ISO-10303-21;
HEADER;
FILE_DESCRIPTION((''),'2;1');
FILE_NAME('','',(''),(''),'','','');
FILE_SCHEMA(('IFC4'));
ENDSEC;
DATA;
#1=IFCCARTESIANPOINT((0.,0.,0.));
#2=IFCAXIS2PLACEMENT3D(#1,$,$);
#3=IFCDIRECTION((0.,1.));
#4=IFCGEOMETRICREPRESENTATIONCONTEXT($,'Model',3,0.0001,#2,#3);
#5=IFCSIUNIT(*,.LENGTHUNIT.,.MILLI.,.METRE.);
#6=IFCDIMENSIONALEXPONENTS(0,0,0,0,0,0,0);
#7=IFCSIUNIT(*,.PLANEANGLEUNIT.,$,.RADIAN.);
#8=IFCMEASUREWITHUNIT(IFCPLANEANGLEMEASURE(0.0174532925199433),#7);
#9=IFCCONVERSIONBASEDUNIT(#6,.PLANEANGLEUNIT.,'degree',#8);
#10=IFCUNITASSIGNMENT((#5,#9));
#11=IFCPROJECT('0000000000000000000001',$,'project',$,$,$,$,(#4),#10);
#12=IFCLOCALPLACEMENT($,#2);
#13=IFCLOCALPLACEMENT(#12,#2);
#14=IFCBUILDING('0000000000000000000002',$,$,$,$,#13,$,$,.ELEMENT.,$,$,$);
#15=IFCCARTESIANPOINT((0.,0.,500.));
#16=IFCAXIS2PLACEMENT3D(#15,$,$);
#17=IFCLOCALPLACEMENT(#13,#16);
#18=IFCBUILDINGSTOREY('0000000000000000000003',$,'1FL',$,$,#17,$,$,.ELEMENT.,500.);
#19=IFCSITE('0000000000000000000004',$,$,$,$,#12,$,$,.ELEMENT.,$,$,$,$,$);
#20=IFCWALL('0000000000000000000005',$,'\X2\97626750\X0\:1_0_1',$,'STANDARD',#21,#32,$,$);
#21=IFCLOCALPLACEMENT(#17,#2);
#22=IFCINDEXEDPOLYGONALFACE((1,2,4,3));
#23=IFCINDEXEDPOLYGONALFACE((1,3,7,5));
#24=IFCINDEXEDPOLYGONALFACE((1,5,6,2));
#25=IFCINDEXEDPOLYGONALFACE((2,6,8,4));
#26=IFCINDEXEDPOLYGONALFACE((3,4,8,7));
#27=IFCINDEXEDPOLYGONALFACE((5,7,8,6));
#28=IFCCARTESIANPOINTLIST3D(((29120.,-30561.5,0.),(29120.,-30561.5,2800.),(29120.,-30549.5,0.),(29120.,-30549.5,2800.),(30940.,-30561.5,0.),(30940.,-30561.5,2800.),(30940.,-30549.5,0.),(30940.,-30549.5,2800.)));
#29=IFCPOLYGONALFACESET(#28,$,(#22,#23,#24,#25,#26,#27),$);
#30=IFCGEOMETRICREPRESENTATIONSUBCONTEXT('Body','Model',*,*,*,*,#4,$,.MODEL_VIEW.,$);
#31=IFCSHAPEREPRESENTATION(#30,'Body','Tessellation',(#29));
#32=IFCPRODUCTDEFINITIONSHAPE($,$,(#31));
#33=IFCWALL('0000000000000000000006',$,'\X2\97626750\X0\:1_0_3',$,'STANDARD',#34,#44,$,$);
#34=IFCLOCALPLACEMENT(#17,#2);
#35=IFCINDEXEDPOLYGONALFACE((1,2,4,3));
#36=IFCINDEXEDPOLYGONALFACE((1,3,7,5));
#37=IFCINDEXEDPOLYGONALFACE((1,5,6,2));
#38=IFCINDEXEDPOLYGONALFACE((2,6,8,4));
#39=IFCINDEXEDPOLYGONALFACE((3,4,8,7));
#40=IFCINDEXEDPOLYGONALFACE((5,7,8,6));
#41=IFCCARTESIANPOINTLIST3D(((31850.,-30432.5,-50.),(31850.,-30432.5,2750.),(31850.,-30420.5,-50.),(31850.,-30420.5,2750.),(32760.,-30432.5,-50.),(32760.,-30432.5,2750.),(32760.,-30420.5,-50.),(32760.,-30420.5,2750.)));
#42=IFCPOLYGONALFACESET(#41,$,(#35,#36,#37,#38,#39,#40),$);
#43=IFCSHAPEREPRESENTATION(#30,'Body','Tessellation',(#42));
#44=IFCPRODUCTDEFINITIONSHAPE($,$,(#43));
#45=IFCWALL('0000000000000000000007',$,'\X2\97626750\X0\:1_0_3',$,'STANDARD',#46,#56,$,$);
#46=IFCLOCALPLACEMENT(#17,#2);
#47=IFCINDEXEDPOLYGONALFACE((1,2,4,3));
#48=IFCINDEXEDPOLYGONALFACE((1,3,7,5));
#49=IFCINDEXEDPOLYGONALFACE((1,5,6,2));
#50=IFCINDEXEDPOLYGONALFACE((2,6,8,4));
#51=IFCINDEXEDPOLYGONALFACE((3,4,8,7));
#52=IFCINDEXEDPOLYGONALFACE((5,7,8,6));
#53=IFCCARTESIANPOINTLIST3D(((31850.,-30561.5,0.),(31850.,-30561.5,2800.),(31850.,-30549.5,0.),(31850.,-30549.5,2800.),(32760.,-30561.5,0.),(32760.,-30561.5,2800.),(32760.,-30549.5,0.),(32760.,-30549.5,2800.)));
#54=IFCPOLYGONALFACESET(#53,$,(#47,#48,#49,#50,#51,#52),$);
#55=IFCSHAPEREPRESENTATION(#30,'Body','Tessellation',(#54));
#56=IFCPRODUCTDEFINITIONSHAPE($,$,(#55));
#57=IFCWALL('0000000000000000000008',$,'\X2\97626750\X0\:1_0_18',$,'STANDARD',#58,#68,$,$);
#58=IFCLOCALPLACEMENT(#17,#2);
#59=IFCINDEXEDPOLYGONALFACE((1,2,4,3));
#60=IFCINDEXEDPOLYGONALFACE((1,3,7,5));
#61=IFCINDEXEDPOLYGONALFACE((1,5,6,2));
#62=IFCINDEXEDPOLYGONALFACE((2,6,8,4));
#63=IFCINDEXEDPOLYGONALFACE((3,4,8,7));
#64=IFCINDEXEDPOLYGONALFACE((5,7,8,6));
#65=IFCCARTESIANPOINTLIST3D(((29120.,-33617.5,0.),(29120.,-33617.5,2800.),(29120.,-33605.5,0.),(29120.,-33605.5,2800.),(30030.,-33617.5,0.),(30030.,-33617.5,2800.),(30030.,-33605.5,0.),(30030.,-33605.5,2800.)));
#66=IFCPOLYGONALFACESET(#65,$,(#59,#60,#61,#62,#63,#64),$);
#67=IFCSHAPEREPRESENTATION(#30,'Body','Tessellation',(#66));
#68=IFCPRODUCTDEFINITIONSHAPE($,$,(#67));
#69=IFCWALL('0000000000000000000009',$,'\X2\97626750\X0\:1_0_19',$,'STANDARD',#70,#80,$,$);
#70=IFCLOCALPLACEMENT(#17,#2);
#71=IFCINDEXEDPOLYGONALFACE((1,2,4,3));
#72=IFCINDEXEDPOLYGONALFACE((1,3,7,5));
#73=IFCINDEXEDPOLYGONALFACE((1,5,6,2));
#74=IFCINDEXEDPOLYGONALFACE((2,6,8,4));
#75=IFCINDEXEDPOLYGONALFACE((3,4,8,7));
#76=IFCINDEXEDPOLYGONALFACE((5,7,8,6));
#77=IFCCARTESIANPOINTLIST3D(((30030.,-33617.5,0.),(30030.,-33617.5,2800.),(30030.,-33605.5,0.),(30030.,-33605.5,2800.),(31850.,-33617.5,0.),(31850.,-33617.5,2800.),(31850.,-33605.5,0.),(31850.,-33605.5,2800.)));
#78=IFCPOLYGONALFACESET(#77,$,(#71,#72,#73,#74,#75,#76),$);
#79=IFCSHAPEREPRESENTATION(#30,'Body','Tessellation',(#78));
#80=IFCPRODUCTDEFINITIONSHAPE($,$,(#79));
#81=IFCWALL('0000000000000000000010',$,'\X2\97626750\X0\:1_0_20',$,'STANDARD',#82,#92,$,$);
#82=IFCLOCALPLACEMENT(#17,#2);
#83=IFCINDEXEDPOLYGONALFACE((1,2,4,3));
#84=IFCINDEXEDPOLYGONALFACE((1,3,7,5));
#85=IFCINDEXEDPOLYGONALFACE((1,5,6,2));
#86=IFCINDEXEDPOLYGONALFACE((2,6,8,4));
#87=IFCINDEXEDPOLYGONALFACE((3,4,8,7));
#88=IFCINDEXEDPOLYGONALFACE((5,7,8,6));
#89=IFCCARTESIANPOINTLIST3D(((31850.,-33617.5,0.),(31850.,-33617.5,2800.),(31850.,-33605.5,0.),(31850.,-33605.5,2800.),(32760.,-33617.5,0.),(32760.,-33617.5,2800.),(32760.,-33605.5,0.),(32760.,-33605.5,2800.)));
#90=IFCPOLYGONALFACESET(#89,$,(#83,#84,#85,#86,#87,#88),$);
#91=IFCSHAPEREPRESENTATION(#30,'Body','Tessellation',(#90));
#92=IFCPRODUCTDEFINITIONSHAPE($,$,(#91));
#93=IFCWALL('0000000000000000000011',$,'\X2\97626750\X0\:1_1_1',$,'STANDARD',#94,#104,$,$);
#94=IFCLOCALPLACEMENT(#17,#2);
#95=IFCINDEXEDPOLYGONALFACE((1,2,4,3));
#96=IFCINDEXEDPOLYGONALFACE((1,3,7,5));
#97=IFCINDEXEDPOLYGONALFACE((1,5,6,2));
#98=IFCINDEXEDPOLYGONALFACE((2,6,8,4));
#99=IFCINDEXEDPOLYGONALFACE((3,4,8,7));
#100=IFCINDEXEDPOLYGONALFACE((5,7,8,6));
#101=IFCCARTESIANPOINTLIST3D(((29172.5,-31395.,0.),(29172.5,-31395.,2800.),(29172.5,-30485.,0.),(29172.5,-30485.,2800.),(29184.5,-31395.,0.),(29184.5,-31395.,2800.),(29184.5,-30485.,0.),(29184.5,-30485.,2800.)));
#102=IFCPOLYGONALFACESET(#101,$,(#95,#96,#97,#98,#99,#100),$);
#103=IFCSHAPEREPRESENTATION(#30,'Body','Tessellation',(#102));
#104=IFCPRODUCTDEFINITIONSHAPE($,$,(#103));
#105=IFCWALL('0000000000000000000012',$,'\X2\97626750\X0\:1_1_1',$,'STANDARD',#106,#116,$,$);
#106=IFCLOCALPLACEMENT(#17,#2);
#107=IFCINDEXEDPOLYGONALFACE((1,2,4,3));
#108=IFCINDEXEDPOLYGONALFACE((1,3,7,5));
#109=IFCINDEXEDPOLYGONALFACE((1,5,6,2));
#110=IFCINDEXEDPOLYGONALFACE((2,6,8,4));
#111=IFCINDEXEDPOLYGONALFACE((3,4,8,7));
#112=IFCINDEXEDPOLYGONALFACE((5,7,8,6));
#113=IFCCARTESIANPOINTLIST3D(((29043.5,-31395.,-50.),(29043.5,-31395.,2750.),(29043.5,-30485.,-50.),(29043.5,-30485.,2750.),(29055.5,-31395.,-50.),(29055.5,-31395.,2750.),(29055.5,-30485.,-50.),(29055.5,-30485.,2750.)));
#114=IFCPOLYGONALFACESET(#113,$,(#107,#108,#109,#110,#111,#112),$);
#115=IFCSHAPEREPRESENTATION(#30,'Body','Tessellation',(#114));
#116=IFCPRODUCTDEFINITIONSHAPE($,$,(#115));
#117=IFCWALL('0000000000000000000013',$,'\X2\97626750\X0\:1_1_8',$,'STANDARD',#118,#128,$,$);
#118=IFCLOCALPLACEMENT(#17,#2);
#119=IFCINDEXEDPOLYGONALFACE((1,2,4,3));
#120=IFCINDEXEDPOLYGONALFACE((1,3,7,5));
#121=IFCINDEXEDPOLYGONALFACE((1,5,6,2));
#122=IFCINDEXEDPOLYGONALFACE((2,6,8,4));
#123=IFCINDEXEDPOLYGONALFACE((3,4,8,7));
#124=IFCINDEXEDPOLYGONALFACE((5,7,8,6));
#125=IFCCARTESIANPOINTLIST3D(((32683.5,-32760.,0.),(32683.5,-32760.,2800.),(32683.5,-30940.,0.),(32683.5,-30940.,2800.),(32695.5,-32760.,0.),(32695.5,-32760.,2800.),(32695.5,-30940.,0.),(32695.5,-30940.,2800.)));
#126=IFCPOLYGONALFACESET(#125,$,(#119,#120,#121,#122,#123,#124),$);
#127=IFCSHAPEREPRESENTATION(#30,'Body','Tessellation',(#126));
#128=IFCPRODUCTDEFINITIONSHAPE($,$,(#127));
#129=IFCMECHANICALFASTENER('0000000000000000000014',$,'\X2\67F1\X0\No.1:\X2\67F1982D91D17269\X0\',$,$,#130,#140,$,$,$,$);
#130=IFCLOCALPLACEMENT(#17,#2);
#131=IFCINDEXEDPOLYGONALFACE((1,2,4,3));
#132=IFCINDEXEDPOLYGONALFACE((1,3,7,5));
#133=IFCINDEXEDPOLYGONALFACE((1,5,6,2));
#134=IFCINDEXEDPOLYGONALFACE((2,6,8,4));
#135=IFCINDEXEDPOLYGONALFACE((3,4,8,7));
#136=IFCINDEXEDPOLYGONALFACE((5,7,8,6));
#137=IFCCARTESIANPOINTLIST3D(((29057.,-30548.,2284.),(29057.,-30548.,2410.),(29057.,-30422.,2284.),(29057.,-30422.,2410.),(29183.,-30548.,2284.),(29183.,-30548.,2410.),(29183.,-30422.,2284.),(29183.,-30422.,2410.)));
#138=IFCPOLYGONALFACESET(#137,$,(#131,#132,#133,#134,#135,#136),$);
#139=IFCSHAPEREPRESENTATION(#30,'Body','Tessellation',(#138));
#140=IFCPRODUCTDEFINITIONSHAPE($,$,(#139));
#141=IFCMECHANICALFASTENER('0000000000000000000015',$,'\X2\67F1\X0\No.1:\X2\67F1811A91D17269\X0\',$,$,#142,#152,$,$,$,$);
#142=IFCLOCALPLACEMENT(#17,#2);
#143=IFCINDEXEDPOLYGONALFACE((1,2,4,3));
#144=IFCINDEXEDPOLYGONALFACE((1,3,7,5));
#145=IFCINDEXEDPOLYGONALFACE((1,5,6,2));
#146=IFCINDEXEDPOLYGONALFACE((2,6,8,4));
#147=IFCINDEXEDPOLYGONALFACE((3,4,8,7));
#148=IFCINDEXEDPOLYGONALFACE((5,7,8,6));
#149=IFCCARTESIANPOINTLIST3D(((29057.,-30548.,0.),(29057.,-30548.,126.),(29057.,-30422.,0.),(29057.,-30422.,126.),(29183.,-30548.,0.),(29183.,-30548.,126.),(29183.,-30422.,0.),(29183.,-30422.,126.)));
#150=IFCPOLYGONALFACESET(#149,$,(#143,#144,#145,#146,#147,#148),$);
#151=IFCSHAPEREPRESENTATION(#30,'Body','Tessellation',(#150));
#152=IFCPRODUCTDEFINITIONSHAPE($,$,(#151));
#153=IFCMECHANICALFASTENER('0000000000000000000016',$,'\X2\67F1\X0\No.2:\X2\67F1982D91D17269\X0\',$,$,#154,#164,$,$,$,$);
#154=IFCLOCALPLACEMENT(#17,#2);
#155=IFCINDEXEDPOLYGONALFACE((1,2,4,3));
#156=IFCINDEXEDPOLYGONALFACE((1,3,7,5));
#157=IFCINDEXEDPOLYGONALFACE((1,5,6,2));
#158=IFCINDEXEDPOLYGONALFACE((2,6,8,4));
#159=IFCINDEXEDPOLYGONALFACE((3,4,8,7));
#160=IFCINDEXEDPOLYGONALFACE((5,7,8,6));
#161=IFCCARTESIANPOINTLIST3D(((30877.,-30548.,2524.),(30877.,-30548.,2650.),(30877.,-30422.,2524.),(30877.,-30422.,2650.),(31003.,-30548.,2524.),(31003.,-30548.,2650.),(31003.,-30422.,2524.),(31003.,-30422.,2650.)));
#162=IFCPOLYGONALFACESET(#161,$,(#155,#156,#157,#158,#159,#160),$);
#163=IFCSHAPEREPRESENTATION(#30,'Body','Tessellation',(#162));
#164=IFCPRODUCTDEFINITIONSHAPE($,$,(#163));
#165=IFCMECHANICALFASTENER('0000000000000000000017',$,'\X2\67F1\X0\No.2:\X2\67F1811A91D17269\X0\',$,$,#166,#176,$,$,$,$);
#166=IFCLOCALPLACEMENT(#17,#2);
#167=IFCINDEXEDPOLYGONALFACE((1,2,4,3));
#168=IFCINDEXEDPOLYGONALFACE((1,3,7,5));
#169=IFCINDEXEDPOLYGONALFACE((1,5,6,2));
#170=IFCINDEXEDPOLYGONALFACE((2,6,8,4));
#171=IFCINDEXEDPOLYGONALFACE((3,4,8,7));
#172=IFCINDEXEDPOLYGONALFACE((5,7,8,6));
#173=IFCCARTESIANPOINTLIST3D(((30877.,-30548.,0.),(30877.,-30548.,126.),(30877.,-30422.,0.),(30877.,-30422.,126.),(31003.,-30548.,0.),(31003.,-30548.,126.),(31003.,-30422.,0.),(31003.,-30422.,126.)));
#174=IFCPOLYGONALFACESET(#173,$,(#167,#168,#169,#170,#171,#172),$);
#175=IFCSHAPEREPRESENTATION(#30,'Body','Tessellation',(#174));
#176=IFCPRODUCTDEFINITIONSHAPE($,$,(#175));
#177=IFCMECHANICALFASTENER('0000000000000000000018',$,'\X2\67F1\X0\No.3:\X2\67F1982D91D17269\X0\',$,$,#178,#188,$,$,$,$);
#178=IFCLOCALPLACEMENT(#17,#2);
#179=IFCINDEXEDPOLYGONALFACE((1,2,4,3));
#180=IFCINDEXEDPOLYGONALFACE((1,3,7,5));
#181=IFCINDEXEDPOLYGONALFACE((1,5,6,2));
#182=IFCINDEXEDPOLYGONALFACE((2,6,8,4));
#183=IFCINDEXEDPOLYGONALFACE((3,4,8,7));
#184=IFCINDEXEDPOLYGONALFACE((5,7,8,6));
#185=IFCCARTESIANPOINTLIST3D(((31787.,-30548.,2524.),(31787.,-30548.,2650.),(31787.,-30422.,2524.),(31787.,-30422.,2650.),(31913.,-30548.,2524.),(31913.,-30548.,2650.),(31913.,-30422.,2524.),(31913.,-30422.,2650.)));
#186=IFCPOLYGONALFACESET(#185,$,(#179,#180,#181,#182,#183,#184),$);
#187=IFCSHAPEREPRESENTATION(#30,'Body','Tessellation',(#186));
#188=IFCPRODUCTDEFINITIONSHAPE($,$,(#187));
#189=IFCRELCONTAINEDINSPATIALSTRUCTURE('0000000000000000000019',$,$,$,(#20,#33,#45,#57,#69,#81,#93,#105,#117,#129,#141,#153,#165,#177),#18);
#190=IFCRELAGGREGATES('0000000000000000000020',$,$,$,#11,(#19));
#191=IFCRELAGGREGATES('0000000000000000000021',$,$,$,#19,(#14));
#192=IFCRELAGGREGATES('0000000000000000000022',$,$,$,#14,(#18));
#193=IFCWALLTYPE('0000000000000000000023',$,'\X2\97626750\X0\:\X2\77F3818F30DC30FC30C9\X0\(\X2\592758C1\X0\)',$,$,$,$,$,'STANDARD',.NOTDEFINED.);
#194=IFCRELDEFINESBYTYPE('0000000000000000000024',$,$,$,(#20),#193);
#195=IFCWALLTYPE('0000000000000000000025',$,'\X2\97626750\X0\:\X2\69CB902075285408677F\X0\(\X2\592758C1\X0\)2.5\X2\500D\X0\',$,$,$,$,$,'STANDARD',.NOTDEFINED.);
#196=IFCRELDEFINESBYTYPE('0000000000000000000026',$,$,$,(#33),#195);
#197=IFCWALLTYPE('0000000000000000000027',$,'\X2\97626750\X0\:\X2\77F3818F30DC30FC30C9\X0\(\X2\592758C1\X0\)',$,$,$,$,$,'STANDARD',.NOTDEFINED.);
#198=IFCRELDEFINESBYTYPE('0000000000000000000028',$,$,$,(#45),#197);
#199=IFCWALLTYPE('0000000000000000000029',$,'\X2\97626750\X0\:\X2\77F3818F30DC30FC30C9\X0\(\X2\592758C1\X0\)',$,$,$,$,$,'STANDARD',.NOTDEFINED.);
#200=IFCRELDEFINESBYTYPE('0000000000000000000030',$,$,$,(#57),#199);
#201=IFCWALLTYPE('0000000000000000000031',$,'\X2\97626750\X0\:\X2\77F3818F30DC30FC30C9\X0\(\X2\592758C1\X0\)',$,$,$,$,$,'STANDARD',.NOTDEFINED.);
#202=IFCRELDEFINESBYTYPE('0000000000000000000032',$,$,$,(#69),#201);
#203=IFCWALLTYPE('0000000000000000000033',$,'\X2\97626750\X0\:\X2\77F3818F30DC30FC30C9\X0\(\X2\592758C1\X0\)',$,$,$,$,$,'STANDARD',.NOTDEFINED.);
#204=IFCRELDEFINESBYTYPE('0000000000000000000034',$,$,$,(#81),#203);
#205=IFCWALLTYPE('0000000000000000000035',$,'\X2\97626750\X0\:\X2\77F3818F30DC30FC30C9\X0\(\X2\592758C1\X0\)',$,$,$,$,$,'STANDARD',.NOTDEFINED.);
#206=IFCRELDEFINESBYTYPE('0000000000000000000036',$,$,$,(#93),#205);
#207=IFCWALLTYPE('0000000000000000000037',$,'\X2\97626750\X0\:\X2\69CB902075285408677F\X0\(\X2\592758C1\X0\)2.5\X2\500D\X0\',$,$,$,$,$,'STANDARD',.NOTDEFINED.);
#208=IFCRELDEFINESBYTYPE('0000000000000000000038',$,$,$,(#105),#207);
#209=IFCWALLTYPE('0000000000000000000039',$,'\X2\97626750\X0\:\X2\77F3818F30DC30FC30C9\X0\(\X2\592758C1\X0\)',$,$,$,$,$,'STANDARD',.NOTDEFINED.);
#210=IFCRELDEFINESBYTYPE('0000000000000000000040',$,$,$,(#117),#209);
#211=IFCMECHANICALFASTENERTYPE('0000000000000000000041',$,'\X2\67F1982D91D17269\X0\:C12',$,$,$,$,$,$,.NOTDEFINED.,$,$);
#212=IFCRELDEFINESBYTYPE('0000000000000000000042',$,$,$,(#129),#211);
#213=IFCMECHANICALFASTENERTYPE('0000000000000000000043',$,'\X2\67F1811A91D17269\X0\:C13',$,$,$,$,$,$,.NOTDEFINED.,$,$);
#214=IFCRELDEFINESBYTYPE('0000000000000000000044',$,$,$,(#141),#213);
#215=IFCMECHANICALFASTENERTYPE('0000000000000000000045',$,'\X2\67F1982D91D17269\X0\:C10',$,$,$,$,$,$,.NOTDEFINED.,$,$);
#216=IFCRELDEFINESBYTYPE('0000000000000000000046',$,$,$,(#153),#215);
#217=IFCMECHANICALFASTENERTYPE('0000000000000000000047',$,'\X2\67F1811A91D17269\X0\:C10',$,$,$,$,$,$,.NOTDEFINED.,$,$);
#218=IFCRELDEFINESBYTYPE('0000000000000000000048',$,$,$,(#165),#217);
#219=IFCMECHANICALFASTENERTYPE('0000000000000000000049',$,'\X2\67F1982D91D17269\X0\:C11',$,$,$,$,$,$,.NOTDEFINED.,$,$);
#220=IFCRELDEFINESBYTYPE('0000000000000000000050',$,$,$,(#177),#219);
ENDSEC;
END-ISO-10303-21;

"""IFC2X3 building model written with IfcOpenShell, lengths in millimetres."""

from ifc_helpers import new_model, entity, si_unit, converted_unit, direction, frame, origin, origin_with_axes, origin_2d, place, context, subcontext, project, spatial, polyline, rectangle, outline, extrude, type_object, element, save


model = new_model("IFC2X3")

# Units and contexts
model_context = context("Model", 3, precision=0.0001, world=origin(), true_north=direction((0.0, 1.0)))
body_context = subcontext(model_context, "Body", "Model", "MODEL_VIEW")
ifc_project = project(units=[si_unit("LENGTHUNIT", "METRE", prefix="MILLI"), converted_unit("PLANEANGLEUNIT", "degree", entity("IfcPlaneAngleMeasure", 0.0174532925199433), si_unit("PLANEANGLEUNIT", "RADIAN"), dimensions=[0, 0, 0, 0, 0, 0, 0])], contexts=[model_context])

# Site, building, storey
site_placement = place(None, origin())
site = spatial("IfcSite", under=ifc_project, at=site_placement, CompositionType="ELEMENT")
building_placement = place(site_placement, origin())
building = spatial("IfcBuilding", under=site, at=building_placement, CompositionType="ELEMENT")
storey_placement = place(building_placement, frame((0.0, 0.0, 500.0)))
storey = spatial("IfcBuildingStorey", under=building, at=storey_placement, Name="1FL", CompositionType="ELEMENT", Elevation=500.0)

# Walls
wall_type_1 = type_object("IfcWallType", Name="面材:石膏ボード(大壁)", ElementType="STANDARD", PredefinedType="NOTDEFINED")
wall_1_placement = place(storey_placement, frame((30030.0, -30549.5, 0.0), z_axis=(0.0, -1.0, 0.0), x_axis=(1.0, 0.0, 0.0)))
element("IfcWall", 1, at=wall_1_placement, inside=storey, type_object=wall_type_1, Name="面材:1_0_1", ObjectType="STANDARD", context=body_context, shape_type="SweptSolid", body=[
    extrude(outline(polyline([(910.0, 0.0, 0.0), (-910.0, 0.0, 0.0), (-910.0, 2800.0, 0.0), (910.0, 2800.0, 0.0), (910.0, 0.0, 0.0)])), origin_with_axes(), (0.0, 0.0, 1.0), 12.0),
])
wall_type_2 = type_object("IfcWallType", Name="面材:構造用合板(大壁)2.5倍", ElementType="STANDARD", PredefinedType="NOTDEFINED")
wall_2_placement = place(storey_placement, frame((32305.0, -30420.5, -50.0), z_axis=(0.0, -1.0, 0.0), x_axis=(1.0, 0.0, 0.0)))
element("IfcWall", 2, at=wall_2_placement, inside=storey, type_object=wall_type_2, Name="面材:1_0_3", ObjectType="STANDARD", context=body_context, shape_type="SweptSolid", body=[
    extrude(outline(polyline([(455.0, 0.0, 0.0), (-455.0, 0.0, 0.0), (-455.0, 2800.0, 0.0), (455.0, 2800.0, 0.0), (455.0, 0.0, 0.0)])), origin_with_axes(), (0.0, 0.0, 1.0), 12.0),
])
wall_type_3 = type_object("IfcWallType", Name="面材:石膏ボード(大壁)", ElementType="STANDARD", PredefinedType="NOTDEFINED")
wall_3_placement = place(storey_placement, frame((32305.0, -30549.5, 0.0), z_axis=(0.0, -1.0, 0.0), x_axis=(1.0, 0.0, 0.0)))
element("IfcWall", 3, at=wall_3_placement, inside=storey, type_object=wall_type_3, Name="面材:1_0_3", ObjectType="STANDARD", context=body_context, shape_type="SweptSolid", body=[
    extrude(outline(polyline([(455.0, 0.0, 0.0), (-455.0, 0.0, 0.0), (-455.0, 2800.0, 0.0), (455.0, 2800.0, 0.0), (455.0, 0.0, 0.0)])), origin_with_axes(), (0.0, 0.0, 1.0), 12.0),
])
wall_type_4 = type_object("IfcWallType", Name="面材:石膏ボード(大壁)", ElementType="STANDARD", PredefinedType="NOTDEFINED")
wall_4_placement = place(storey_placement, frame((29575.0, -33605.5, 0.0), z_axis=(0.0, -1.0, 0.0), x_axis=(1.0, 0.0, 0.0)))
element("IfcWall", 4, at=wall_4_placement, inside=storey, type_object=wall_type_4, Name="面材:1_0_18", ObjectType="STANDARD", context=body_context, shape_type="SweptSolid", body=[
    extrude(outline(polyline([(455.0, 0.0, 0.0), (-455.0, 0.0, 0.0), (-455.0, 2800.0, 0.0), (455.0, 2800.0, 0.0), (455.0, 0.0, 0.0)])), origin_with_axes(), (0.0, 0.0, 1.0), 12.0),
])
wall_type_5 = type_object("IfcWallType", Name="面材:石膏ボード(大壁)", ElementType="STANDARD", PredefinedType="NOTDEFINED")
wall_5_placement = place(storey_placement, frame((30940.0, -33605.5, 0.0), z_axis=(0.0, -1.0, 0.0), x_axis=(1.0, 0.0, 0.0)))
element("IfcWall", 5, at=wall_5_placement, inside=storey, type_object=wall_type_5, Name="面材:1_0_19", ObjectType="STANDARD", context=body_context, shape_type="SweptSolid", body=[
    extrude(outline(polyline([(910.0, 0.0, 0.0), (-910.0, 0.0, 0.0), (-910.0, 2800.0, 0.0), (910.0, 2800.0, 0.0), (910.0, 0.0, 0.0)])), origin_with_axes(), (0.0, 0.0, 1.0), 12.0),
])
wall_type_6 = type_object("IfcWallType", Name="面材:石膏ボード(大壁)", ElementType="STANDARD", PredefinedType="NOTDEFINED")
wall_6_placement = place(storey_placement, frame((32305.0, -33605.5, 0.0), z_axis=(0.0, -1.0, 0.0), x_axis=(1.0, 0.0, 0.0)))
element("IfcWall", 6, at=wall_6_placement, inside=storey, type_object=wall_type_6, Name="面材:1_0_20", ObjectType="STANDARD", context=body_context, shape_type="SweptSolid", body=[
    extrude(outline(polyline([(455.0, 0.0, 0.0), (-455.0, 0.0, 0.0), (-455.0, 2800.0, 0.0), (455.0, 2800.0, 0.0), (455.0, 0.0, 0.0)])), origin_with_axes(), (0.0, 0.0, 1.0), 12.0),
])
wall_type_7 = type_object("IfcWallType", Name="面材:石膏ボード(大壁)", ElementType="STANDARD", PredefinedType="NOTDEFINED")
wall_7_placement = place(storey_placement, frame((29184.5, -30940.0, 0.0), z_axis=(-1.0, 0.0, 0.0), x_axis=(0.0, -1.0, 0.0)))
element("IfcWall", 7, at=wall_7_placement, inside=storey, type_object=wall_type_7, Name="面材:1_1_1", ObjectType="STANDARD", context=body_context, shape_type="SweptSolid", body=[
    extrude(outline(polyline([(455.0, 0.0, 0.0), (-455.0, 0.0, 0.0), (-455.0, 2800.0, 0.0), (455.0, 2800.0, 0.0), (455.0, 0.0, 0.0)])), origin_with_axes(), (0.0, 0.0, 1.0), 12.0),
])
wall_type_8 = type_object("IfcWallType", Name="面材:構造用合板(大壁)2.5倍", ElementType="STANDARD", PredefinedType="NOTDEFINED")
wall_8_placement = place(storey_placement, frame((29055.5, -30940.0, -50.0), z_axis=(-1.0, 0.0, 0.0), x_axis=(0.0, -1.0, 0.0)))
element("IfcWall", 8, at=wall_8_placement, inside=storey, type_object=wall_type_8, Name="面材:1_1_1", ObjectType="STANDARD", context=body_context, shape_type="SweptSolid", body=[
    extrude(outline(polyline([(455.0, 0.0, 0.0), (-455.0, 0.0, 0.0), (-455.0, 2800.0, 0.0), (455.0, 2800.0, 0.0), (455.0, 0.0, 0.0)])), origin_with_axes(), (0.0, 0.0, 1.0), 12.0),
])
wall_type_9 = type_object("IfcWallType", Name="面材:石膏ボード(大壁)", ElementType="STANDARD", PredefinedType="NOTDEFINED")
wall_9_placement = place(storey_placement, frame((32695.5, -31850.0, 0.0), z_axis=(-1.0, 0.0, 0.0), x_axis=(0.0, -1.0, 0.0)))
element("IfcWall", 9, at=wall_9_placement, inside=storey, type_object=wall_type_9, Name="面材:1_1_8", ObjectType="STANDARD", context=body_context, shape_type="SweptSolid", body=[
    extrude(outline(polyline([(910.0, 0.0, 0.0), (-910.0, 0.0, 0.0), (-910.0, 2800.0, 0.0), (910.0, 2800.0, 0.0), (910.0, 0.0, 0.0)])), origin_with_axes(), (0.0, 0.0, 1.0), 12.0),
])

# Mechanical fasteners
mechanical_fastener_type_1 = type_object("IfcMechanicalFastenerType", Name="柱頭金物:C12")
mechanical_fastener_1_placement = place(storey_placement, frame((29120.0, -30485.0, 2284.0)))
element("IfcMechanicalFastener", 10, at=mechanical_fastener_1_placement, inside=storey, type_object=mechanical_fastener_type_1, Name="柱No.1:柱頭金物", context=body_context, shape_type="SweptSolid", body=[
    extrude(rectangle(XDim=126.0, YDim=126.0, at=origin_2d()), origin_with_axes(), (0.0, 0.0, 1.0), 126.0),
])
mechanical_fastener_type_2 = type_object("IfcMechanicalFastenerType", Name="柱脚金物:C13")
mechanical_fastener_2_placement = place(storey_placement, frame((29120.0, -30485.0, 0.0)))
element("IfcMechanicalFastener", 11, at=mechanical_fastener_2_placement, inside=storey, type_object=mechanical_fastener_type_2, Name="柱No.1:柱脚金物", context=body_context, shape_type="SweptSolid", body=[
    extrude(rectangle(XDim=126.0, YDim=126.0, at=origin_2d()), origin_with_axes(), (0.0, 0.0, 1.0), 126.0),
])
mechanical_fastener_type_3 = type_object("IfcMechanicalFastenerType", Name="柱頭金物:C10")
mechanical_fastener_3_placement = place(storey_placement, frame((30940.0, -30485.0, 2524.0)))
element("IfcMechanicalFastener", 12, at=mechanical_fastener_3_placement, inside=storey, type_object=mechanical_fastener_type_3, Name="柱No.2:柱頭金物", context=body_context, shape_type="SweptSolid", body=[
    extrude(rectangle(XDim=126.0, YDim=126.0, at=origin_2d()), origin_with_axes(), (0.0, 0.0, 1.0), 126.0),
])
mechanical_fastener_type_4 = type_object("IfcMechanicalFastenerType", Name="柱脚金物:C10")
mechanical_fastener_4_placement = place(storey_placement, frame((30940.0, -30485.0, 0.0)))
element("IfcMechanicalFastener", 13, at=mechanical_fastener_4_placement, inside=storey, type_object=mechanical_fastener_type_4, Name="柱No.2:柱脚金物", context=body_context, shape_type="SweptSolid", body=[
    extrude(rectangle(XDim=126.0, YDim=126.0, at=origin_2d()), origin_with_axes(), (0.0, 0.0, 1.0), 126.0),
])
mechanical_fastener_type_5 = type_object("IfcMechanicalFastenerType", Name="柱頭金物:C11")
mechanical_fastener_5_placement = place(storey_placement, frame((31850.0, -30485.0, 2524.0)))
element("IfcMechanicalFastener", 14, at=mechanical_fastener_5_placement, inside=storey, type_object=mechanical_fastener_type_5, Name="柱No.3:柱頭金物", context=body_context, shape_type="SweptSolid", body=[
    extrude(rectangle(XDim=126.0, YDim=126.0, at=origin_2d()), origin_with_axes(), (0.0, 0.0, 1.0), 126.0),
])

save(model, "model.ifc")
